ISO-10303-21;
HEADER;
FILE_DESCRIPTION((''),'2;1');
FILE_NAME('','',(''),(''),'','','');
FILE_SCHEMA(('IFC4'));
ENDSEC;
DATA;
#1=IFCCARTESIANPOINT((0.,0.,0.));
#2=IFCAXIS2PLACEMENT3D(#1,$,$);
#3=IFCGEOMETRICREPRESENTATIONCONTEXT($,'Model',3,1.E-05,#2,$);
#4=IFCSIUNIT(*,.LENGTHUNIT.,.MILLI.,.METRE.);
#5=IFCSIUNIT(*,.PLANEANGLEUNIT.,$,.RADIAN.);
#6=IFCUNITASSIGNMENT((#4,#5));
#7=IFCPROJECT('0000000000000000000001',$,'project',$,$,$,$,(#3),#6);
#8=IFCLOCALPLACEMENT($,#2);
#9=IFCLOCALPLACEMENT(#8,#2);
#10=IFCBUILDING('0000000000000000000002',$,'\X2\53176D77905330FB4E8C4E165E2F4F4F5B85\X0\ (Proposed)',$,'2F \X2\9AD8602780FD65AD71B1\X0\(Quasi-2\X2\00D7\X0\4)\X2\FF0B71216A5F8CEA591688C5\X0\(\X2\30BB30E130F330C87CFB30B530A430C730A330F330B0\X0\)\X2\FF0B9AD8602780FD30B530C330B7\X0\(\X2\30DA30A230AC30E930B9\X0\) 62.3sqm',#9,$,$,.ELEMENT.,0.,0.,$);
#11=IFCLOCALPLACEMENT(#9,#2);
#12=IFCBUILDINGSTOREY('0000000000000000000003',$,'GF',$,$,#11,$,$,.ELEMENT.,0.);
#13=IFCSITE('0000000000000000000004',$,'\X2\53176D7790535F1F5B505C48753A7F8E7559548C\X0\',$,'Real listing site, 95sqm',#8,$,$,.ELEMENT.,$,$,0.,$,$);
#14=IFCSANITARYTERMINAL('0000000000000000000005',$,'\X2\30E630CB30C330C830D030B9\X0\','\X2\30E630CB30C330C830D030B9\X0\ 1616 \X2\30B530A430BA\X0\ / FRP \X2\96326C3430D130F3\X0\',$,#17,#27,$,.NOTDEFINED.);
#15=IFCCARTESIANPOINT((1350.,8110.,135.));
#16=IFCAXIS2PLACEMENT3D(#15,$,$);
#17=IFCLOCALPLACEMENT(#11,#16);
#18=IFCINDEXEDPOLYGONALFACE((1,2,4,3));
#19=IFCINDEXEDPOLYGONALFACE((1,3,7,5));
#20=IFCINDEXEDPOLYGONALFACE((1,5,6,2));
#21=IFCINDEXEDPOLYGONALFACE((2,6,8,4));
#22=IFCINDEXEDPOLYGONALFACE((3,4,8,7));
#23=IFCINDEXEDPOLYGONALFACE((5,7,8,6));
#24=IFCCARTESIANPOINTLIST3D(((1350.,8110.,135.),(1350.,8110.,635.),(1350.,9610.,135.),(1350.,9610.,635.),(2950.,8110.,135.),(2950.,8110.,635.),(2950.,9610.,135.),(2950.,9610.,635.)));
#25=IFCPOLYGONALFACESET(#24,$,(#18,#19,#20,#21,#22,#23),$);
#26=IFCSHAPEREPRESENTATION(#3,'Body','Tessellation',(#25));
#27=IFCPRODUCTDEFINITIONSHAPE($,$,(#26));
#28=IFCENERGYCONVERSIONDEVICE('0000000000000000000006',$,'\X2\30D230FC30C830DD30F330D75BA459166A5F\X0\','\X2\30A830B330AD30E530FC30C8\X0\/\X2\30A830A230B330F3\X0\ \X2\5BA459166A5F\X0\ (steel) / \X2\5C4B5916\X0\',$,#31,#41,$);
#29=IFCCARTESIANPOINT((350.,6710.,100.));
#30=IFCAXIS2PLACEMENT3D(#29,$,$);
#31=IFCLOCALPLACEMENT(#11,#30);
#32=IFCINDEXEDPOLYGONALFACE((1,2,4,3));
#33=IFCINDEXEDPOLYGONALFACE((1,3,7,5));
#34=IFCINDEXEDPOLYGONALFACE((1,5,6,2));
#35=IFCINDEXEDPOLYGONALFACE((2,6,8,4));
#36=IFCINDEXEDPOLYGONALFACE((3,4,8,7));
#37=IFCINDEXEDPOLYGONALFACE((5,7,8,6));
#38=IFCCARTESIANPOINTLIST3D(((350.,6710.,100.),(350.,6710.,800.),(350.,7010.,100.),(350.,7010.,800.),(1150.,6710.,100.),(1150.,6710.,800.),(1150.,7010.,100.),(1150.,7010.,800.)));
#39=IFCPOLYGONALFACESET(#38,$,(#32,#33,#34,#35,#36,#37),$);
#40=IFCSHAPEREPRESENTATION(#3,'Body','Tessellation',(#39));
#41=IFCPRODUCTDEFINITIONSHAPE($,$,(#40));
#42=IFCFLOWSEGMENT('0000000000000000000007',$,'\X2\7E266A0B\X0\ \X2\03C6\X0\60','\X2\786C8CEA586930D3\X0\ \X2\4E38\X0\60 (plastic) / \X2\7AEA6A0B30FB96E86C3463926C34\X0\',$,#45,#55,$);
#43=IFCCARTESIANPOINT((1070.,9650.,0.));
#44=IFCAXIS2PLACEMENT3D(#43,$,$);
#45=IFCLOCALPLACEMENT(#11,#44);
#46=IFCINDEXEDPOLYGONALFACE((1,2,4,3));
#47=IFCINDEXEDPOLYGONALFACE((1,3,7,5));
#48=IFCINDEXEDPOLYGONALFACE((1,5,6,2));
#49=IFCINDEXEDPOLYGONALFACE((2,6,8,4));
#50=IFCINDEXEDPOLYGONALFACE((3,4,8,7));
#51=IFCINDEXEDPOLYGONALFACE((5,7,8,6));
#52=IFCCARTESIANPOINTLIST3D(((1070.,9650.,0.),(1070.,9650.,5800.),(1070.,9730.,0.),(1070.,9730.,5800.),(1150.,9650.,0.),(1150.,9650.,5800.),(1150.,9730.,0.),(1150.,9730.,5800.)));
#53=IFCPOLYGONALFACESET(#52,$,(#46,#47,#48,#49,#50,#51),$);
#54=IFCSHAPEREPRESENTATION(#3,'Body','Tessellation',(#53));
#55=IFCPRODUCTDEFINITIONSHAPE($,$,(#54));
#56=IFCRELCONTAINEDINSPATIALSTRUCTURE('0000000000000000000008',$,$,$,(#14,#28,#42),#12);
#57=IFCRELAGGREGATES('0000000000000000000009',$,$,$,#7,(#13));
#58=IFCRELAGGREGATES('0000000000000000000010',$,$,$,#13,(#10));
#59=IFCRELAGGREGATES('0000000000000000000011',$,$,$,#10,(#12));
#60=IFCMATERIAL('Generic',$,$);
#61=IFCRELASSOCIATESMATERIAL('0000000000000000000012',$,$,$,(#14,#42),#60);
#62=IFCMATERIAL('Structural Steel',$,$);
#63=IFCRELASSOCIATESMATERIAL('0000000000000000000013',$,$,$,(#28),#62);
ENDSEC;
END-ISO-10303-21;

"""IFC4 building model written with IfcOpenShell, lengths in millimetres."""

from ifc_helpers import new_model, si_unit, frame, frame_2d, origin, place, context, project, spatial, rectangle, extrude, material, element, save


model = new_model("IFC4")

# Units and contexts
model_context = context("Model", 3, precision=1e-05, world=origin())
ifc_project = project(units=[si_unit("LENGTHUNIT", "METRE", prefix="MILLI"), si_unit("PLANEANGLEUNIT", "RADIAN")], contexts=[model_context])

# Site, building, storey
site_placement = place(None, origin())
site = spatial("IfcSite", under=ifc_project, at=site_placement, Name="北海道弟子屈町美留和", ObjectType="Real listing site, 95sqm", CompositionType="ELEMENT", RefElevation=0.0)
building_placement = place(site_placement, origin())
building = spatial("IfcBuilding", under=site, at=building_placement, Name="北海道・二世帯住宅 (Proposed)", ObjectType="2F 高性能断熱(Quasi-2×4)＋無機質外装(セメント系サイディング)＋高性能サッシ(ペアガラス) 62.3sqm", CompositionType="ELEMENT", ElevationOfRefHeight=0.0, ElevationOfTerrain=0.0)
storey_placement = place(building_placement, origin())
storey = spatial("IfcBuildingStorey", under=building, at=storey_placement, Name="GF", CompositionType="ELEMENT", Elevation=0.0)

# Shared definitions
ifc_material_1 = material(Name="Generic")

# Sanitary terminal
sanitary_terminal_placement = place(storey_placement, frame((1350.0, 8110.0, 135.0)))
element("IfcSanitaryTerminal", 1, at=sanitary_terminal_placement, inside=storey, material=ifc_material_1, Name="ユニットバス", Description="ユニットバス 1616 サイズ / FRP 防水パン", PredefinedType="NOTDEFINED", context=model_context, shape_type="SweptSolid", body=[
    extrude(rectangle(XDim=1600.0, YDim=1500.0, at=frame_2d((800.0, 750.0))), frame((1350.0, 8110.0, 135.0)), (0.0, 0.0, 1.0), 500.0),
])

# Energy conversion device
ifc_material_2 = material(Name="Structural Steel")
energy_conversion_device_placement = place(storey_placement, frame((350.0, 6710.0, 100.0)))
element("IfcEnergyConversionDevice", 2, at=energy_conversion_device_placement, inside=storey, material=ifc_material_2, Name="ヒートポンプ室外機", Description="エコキュート/エアコン 室外機 (steel) / 屋外", context=model_context, shape_type="SweptSolid", body=[
    extrude(rectangle(XDim=800.0, YDim=300.0, at=frame_2d((400.0, 150.0))), frame((350.0, 6710.0, 100.0)), (0.0, 0.0, 1.0), 700.0),
])

# Flow segment
flow_segment_placement = place(storey_placement, frame((1070.0, 9650.0, 0.0)))
element("IfcFlowSegment", 3, at=flow_segment_placement, inside=storey, material=ifc_material_1, Name="縦樋 φ60", Description="硬質塩ビ 丸60 (plastic) / 竪樋・雨水排水", context=model_context, shape_type="SweptSolid", body=[
    extrude(rectangle(XDim=80.0, YDim=80.0, at=frame_2d((40.0, 40.0))), frame((1070.0, 9650.0, 0.0)), (0.0, 0.0, 1.0), 5800.0),
])

save(model, "model.ifc")
